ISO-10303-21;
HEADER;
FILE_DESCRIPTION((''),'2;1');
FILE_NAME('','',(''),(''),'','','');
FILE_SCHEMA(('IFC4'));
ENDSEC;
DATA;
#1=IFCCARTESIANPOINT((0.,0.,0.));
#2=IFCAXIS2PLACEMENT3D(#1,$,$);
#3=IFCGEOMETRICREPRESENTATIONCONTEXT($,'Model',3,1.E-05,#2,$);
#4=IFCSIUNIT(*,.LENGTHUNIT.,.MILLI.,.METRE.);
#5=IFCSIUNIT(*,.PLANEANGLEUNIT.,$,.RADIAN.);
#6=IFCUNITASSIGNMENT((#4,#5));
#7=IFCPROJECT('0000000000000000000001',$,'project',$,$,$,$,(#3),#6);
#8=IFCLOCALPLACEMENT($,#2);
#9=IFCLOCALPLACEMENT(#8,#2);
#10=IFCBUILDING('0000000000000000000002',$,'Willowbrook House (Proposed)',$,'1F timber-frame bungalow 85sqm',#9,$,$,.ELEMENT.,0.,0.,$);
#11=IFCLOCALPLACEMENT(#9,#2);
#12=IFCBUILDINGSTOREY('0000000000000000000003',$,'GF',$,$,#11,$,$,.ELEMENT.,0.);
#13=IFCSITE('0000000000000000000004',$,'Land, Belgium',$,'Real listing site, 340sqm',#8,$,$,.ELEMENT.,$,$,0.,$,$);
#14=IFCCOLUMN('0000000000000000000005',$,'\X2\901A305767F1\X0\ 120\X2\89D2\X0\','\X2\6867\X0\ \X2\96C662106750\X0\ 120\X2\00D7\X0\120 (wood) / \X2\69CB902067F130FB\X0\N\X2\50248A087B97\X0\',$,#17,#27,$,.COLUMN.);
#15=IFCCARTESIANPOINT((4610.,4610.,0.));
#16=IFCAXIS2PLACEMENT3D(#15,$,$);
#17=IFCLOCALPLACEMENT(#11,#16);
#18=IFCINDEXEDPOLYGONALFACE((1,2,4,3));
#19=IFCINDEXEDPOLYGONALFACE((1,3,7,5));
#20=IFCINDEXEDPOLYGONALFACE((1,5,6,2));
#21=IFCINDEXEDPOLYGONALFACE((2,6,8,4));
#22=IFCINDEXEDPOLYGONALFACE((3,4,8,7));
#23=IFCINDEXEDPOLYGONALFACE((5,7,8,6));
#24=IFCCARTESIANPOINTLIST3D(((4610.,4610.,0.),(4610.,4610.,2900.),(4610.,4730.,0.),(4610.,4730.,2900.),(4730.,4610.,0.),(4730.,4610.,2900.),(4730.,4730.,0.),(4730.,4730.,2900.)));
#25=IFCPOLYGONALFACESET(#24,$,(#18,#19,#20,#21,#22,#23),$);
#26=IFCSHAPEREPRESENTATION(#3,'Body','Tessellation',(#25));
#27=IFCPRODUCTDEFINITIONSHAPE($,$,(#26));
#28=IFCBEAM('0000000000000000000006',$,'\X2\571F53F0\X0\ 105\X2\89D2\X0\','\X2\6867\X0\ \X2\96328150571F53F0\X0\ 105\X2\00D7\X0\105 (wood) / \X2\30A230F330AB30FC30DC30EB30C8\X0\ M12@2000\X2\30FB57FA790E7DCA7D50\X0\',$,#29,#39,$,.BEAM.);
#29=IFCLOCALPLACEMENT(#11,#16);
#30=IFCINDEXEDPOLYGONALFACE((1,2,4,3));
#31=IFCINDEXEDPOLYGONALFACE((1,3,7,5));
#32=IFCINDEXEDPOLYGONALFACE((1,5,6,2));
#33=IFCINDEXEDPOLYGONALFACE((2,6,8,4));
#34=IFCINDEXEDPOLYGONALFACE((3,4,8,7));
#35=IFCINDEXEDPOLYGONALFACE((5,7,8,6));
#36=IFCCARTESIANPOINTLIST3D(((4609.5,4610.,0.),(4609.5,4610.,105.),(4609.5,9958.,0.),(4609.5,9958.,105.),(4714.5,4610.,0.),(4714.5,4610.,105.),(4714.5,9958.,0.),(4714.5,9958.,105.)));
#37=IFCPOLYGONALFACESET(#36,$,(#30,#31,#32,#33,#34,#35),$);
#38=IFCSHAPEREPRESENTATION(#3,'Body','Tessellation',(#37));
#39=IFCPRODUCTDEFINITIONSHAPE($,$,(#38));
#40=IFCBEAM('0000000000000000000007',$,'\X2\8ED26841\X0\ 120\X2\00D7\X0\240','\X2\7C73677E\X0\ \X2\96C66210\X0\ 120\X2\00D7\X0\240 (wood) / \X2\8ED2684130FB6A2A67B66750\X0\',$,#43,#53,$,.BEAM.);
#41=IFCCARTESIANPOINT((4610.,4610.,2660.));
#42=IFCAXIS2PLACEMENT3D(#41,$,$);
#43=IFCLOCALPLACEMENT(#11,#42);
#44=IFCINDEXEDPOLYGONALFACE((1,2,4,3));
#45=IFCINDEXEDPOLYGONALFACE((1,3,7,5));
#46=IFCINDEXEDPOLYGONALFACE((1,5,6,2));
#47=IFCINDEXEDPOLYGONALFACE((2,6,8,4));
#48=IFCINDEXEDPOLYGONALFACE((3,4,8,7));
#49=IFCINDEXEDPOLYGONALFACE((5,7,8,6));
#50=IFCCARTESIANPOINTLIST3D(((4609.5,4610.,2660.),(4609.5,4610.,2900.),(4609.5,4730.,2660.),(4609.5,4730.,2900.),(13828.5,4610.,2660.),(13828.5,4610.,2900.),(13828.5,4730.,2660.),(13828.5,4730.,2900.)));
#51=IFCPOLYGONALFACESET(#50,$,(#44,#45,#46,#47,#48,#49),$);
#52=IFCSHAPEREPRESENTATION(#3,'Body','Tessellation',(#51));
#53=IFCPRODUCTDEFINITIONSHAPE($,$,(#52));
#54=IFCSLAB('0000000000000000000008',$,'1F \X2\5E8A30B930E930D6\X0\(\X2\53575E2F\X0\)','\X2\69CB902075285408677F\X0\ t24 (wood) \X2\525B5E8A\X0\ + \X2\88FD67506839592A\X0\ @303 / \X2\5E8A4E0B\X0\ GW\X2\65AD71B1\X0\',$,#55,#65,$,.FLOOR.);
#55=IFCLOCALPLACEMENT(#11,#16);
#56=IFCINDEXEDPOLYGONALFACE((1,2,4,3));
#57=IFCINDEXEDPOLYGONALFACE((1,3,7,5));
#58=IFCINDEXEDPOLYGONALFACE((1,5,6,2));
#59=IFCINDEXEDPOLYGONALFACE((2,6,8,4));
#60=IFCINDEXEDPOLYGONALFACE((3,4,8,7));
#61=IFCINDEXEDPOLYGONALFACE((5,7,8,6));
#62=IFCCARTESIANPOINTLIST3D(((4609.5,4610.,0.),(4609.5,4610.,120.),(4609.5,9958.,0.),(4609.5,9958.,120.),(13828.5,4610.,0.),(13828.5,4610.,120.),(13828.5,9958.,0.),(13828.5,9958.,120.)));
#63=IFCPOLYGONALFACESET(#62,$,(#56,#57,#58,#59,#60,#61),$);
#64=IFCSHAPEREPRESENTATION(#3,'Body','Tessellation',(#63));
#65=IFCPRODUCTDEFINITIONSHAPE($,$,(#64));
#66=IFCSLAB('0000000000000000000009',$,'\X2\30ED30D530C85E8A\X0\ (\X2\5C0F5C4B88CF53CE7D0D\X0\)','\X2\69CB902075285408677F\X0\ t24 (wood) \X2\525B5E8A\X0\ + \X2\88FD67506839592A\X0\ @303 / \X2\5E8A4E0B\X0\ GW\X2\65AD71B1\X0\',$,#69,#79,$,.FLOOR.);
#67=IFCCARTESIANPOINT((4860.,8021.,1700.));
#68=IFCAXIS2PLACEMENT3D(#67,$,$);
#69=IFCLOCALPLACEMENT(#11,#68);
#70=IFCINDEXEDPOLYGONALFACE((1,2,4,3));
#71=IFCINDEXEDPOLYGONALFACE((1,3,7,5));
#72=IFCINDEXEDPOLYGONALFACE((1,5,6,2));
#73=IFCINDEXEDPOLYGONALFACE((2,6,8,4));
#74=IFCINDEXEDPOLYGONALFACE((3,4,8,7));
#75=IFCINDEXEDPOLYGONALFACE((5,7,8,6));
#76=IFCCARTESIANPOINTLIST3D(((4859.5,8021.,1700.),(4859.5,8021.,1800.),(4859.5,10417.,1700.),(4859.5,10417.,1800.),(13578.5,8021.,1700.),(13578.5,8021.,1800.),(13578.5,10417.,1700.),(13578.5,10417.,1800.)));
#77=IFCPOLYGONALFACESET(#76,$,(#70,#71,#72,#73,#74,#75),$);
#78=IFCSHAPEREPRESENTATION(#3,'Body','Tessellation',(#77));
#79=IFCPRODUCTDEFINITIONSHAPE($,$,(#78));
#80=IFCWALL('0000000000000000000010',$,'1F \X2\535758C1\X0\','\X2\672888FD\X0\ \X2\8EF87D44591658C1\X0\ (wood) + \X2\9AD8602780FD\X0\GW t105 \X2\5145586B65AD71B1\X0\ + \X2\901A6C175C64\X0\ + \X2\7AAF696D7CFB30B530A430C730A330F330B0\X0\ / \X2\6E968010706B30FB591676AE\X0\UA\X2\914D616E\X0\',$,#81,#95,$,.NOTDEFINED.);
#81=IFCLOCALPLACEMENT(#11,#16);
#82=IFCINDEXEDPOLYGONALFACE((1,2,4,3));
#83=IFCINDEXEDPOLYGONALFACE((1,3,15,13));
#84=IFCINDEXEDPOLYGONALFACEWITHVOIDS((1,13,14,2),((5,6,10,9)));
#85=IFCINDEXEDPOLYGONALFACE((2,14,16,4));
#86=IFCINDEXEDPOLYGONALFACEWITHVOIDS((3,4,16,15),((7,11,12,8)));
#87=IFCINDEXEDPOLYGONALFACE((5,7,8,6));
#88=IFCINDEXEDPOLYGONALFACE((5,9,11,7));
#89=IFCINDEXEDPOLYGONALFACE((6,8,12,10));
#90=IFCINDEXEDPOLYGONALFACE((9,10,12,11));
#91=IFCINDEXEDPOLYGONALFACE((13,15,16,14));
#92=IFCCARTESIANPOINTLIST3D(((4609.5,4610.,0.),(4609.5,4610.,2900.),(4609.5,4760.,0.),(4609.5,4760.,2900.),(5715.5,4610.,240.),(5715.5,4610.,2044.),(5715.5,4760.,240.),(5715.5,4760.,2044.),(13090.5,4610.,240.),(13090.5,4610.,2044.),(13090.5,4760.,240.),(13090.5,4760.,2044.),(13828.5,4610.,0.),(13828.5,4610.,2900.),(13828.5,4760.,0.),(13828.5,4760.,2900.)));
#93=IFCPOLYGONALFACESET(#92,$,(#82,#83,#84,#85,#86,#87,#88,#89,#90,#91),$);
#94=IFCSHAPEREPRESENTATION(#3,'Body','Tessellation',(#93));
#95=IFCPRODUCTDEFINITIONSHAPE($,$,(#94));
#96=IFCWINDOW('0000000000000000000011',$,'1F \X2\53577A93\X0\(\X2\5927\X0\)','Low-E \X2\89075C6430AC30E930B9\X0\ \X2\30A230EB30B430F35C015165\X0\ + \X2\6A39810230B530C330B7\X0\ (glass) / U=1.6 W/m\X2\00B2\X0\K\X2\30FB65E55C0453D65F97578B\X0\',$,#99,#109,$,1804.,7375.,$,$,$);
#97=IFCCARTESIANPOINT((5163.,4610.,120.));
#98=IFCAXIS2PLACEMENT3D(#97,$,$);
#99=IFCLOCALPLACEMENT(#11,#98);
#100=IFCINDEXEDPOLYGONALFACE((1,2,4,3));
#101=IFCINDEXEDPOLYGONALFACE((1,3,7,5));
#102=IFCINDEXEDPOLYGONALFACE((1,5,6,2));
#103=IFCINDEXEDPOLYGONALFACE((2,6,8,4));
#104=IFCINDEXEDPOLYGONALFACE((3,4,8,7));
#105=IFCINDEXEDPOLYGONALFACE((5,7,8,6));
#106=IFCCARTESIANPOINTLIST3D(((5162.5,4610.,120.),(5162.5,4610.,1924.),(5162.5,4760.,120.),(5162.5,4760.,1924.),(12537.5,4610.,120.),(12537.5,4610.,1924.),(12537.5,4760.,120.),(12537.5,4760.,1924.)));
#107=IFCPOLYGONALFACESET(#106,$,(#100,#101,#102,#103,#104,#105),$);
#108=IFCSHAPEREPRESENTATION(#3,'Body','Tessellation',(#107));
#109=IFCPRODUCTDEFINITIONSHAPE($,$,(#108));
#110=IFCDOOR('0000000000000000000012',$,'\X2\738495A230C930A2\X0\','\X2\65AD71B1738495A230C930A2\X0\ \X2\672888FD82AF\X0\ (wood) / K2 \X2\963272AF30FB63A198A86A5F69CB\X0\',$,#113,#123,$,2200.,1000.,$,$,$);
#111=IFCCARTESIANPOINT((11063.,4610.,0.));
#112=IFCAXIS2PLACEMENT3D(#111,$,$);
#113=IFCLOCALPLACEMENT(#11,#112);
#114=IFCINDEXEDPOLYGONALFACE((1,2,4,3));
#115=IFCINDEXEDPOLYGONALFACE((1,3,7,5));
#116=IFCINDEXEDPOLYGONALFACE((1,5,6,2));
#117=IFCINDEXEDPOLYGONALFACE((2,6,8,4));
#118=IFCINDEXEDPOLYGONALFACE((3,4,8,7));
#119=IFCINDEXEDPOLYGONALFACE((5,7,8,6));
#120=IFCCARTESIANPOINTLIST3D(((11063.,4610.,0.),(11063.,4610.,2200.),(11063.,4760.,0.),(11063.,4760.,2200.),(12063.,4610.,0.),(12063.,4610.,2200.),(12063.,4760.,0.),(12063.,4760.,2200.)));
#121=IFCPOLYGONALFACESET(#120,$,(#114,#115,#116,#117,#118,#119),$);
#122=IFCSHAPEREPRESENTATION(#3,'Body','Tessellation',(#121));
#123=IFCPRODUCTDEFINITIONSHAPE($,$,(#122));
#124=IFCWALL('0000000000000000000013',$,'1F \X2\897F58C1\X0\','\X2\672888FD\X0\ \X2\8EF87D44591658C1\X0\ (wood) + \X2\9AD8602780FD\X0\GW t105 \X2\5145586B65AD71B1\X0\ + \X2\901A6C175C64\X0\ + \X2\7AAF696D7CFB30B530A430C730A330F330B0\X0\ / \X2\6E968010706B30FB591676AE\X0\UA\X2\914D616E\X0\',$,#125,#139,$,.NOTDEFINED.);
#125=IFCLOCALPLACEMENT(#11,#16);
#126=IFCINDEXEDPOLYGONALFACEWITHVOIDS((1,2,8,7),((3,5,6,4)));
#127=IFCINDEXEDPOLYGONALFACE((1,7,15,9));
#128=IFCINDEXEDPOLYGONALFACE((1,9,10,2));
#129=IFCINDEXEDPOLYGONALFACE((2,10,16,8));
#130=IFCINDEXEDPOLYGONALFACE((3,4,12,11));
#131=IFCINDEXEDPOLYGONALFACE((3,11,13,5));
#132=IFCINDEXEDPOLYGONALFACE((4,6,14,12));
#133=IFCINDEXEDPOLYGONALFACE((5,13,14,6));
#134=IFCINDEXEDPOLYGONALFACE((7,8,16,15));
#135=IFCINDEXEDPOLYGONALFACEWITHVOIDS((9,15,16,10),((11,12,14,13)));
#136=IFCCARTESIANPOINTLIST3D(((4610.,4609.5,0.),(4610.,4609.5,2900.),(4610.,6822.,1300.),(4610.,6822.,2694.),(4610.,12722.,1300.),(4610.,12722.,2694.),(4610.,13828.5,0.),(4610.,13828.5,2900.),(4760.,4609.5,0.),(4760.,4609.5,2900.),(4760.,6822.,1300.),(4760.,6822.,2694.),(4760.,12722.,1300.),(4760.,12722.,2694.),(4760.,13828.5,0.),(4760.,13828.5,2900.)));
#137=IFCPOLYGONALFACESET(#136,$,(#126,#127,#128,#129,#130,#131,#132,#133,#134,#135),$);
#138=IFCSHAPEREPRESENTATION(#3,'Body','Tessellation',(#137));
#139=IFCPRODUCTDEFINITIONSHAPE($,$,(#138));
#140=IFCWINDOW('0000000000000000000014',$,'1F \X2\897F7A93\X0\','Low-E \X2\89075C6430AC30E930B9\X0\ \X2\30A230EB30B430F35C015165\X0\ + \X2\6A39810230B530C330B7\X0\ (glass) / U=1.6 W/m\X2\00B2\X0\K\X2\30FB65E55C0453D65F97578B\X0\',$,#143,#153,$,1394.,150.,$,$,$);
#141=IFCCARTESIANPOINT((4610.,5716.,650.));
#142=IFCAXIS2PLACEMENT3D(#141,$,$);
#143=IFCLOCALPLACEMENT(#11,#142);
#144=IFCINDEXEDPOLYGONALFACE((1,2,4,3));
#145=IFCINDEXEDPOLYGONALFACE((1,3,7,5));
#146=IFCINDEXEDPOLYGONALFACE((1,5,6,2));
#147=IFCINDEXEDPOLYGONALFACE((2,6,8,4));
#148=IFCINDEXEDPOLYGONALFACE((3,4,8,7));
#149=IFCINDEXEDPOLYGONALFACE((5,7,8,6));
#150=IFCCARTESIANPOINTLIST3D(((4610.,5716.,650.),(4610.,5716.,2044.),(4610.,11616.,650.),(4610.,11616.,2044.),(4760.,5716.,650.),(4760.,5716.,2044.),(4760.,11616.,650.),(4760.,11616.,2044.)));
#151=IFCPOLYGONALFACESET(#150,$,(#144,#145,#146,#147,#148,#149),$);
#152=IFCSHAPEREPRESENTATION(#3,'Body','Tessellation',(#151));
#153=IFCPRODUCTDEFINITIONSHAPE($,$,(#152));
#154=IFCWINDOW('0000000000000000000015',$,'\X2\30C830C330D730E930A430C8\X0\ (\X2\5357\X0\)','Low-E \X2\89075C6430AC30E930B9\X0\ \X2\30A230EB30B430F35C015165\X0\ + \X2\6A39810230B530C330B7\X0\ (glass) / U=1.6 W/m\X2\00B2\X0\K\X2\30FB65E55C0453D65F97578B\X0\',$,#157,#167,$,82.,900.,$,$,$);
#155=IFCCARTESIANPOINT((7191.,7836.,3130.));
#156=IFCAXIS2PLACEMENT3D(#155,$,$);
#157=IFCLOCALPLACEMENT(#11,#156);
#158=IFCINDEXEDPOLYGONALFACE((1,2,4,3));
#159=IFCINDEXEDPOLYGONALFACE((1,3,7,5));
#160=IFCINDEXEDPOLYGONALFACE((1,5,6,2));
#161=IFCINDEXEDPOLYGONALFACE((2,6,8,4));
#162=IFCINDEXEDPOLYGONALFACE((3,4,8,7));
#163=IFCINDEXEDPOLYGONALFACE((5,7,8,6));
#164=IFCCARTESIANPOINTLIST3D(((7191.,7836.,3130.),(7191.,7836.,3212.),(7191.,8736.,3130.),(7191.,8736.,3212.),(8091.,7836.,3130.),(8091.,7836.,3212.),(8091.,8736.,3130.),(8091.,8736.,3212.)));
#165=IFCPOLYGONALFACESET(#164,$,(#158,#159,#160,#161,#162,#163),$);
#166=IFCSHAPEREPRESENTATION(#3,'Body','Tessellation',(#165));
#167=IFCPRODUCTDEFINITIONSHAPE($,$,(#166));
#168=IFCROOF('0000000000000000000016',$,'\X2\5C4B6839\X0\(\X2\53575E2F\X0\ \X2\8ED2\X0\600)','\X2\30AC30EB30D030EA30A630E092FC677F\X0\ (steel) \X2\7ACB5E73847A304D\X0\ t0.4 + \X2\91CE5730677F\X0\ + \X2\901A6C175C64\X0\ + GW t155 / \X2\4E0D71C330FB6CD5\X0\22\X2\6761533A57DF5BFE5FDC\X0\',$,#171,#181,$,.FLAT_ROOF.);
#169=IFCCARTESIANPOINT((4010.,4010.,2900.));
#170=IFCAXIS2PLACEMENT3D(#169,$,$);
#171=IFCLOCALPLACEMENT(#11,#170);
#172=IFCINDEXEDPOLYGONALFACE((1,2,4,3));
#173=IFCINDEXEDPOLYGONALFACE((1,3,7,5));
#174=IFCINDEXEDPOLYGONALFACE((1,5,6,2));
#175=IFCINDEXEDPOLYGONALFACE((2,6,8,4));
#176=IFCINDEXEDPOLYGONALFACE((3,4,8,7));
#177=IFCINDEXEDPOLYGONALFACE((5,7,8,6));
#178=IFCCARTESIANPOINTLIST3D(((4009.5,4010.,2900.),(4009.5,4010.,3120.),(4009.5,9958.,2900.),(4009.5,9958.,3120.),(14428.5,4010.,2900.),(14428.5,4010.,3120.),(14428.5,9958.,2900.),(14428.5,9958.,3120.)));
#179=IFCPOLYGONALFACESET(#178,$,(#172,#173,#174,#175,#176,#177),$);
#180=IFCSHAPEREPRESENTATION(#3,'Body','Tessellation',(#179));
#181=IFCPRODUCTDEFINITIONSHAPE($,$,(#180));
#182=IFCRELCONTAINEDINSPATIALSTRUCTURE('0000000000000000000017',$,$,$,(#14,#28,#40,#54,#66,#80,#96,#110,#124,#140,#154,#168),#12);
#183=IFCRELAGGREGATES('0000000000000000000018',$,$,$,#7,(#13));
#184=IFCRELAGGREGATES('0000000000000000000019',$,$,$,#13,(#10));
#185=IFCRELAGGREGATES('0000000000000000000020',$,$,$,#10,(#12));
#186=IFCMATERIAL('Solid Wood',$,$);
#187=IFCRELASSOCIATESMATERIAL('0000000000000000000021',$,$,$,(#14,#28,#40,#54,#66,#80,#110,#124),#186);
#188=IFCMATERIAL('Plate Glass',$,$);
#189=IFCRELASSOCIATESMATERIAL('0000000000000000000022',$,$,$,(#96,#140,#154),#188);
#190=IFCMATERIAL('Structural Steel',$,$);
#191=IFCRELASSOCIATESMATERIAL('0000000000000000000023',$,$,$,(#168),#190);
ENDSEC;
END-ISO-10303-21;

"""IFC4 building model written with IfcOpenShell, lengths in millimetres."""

from ifc_helpers import new_model, si_unit, frame, frame_2d, origin, place, context, project, spatial, rectangle, extrude, material, element, fill, save


model = new_model("IFC4")

# Units and contexts
model_context = context("Model", 3, precision=1e-05, world=origin())
ifc_project = project(units=[si_unit("LENGTHUNIT", "METRE", prefix="MILLI"), si_unit("PLANEANGLEUNIT", "RADIAN")], contexts=[model_context])

# Site, building, storey
site_placement = place(None, origin())
site = spatial("IfcSite", under=ifc_project, at=site_placement, Name="Land, Belgium", ObjectType="Real listing site, 340sqm", CompositionType="ELEMENT", RefElevation=0.0)
building_placement = place(site_placement, origin())
building = spatial("IfcBuilding", under=site, at=building_placement, Name="Willowbrook House (Proposed)", ObjectType="1F timber-frame bungalow 85sqm", CompositionType="ELEMENT", ElevationOfRefHeight=0.0, ElevationOfTerrain=0.0)
storey_placement = place(building_placement, origin())
storey = spatial("IfcBuildingStorey", under=building, at=storey_placement, Name="GF", CompositionType="ELEMENT", Elevation=0.0)

# Column
ifc_material_1 = material(Name="Solid Wood")
column_1_placement = place(storey_placement, frame((4610.0, 4610.0, 0.0)))
element("IfcColumn", 1, at=column_1_placement, inside=storey, material=ifc_material_1, Name="通し柱 120角", Description="桧 集成材 120×120 (wood) / 構造柱・N値計算", PredefinedType="COLUMN", context=model_context, shape_type="SweptSolid", body=[
    extrude(rectangle(XDim=120.0, YDim=120.0, at=frame_2d((60.0, 60.0))), frame((4610.0, 4610.0, 0.0)), (0.0, 0.0, 1.0), 2900.0),
])

# Beams
beam_1_placement = place(storey_placement, frame((4610.0, 4610.0, 0.0)))
element("IfcBeam", 2, at=beam_1_placement, inside=storey, material=ifc_material_1, Name="土台 105角", Description="桧 防腐土台 105×105 (wood) / アンカーボルト M12@2000・基礎緊結", PredefinedType="BEAM", context=model_context, shape_type="SweptSolid", body=[
    extrude(rectangle(XDim=105.0, YDim=5348.0, at=frame_2d((52.0, 2674.0))), frame((4610.0, 4610.0, 0.0)), (0.0, 0.0, 1.0), 105.0),
])
beam_2_placement = place(storey_placement, frame((4610.0, 4610.0, 2660.0)))
element("IfcBeam", 3, at=beam_2_placement, inside=storey, material=ifc_material_1, Name="軒桁 120×240", Description="米松 集成 120×240 (wood) / 軒桁・横架材", PredefinedType="BEAM", context=model_context, shape_type="SweptSolid", body=[
    extrude(rectangle(XDim=9219.0, YDim=120.0, at=frame_2d((4609.0, 60.0))), frame((4610.0, 4610.0, 2660.0)), (0.0, 0.0, 1.0), 240.0),
])

# Slabs
slab_1_placement = place(storey_placement, frame((4610.0, 4610.0, 0.0)))
element("IfcSlab", 4, at=slab_1_placement, inside=storey, material=ifc_material_1, Name="1F 床スラブ(南帯)", Description="構造用合板 t24 (wood) 剛床 + 製材根太 @303 / 床下 GW断熱", PredefinedType="FLOOR", context=model_context, shape_type="SweptSolid", body=[
    extrude(rectangle(XDim=9219.0, YDim=5348.0, at=frame_2d((4609.0, 2674.0))), frame((4610.0, 4610.0, 0.0)), (0.0, 0.0, 1.0), 120.0),
])
slab_2_placement = place(storey_placement, frame((4860.0, 8021.0, 1700.0)))
element("IfcSlab", 5, at=slab_2_placement, inside=storey, material=ifc_material_1, Name="ロフト床 (小屋裏収納)", Description="構造用合板 t24 (wood) 剛床 + 製材根太 @303 / 床下 GW断熱", PredefinedType="FLOOR", context=model_context, shape_type="SweptSolid", body=[
    extrude(rectangle(XDim=8719.0, YDim=2396.0, at=frame_2d((4359.0, 1198.0))), frame((4860.0, 8021.0, 1700.0)), (0.0, 0.0, 1.0), 100.0),
])

# Wall, openings, window, door
wall_1_placement = place(storey_placement, frame((4610.0, 4610.0, 0.0)))
wall_1 = element("IfcWall", 6, at=wall_1_placement, inside=storey, material=ifc_material_1, Name="1F 南壁", Description="木製 軸組外壁 (wood) + 高性能GW t105 充填断熱 + 通気層 + 窯業系サイディング / 準耐火・外皮UA配慮", PredefinedType="NOTDEFINED", context=model_context, shape_type="SweptSolid", body=[
    extrude(rectangle(XDim=9219.0, YDim=150.0, at=frame_2d((4609.0, 75.0))), frame((4610.0, 4610.0, 0.0)), (0.0, 0.0, 1.0), 2900.0),
])
opening_1_placement = place(storey_placement, frame((5163.0, 4610.0, 120.0)))
opening_1 = element("IfcOpeningElement", 7, at=opening_1_placement, cuts=wall_1, PredefinedType="NOTDEFINED", context=model_context, shape_type="SweptSolid", body=[
    extrude(rectangle(XDim=7375.0, YDim=150.0, at=frame_2d((3687.0, 75.0))), frame((5163.0, 4610.0, 120.0)), (0.0, 0.0, 1.0), 1804.0),
])
opening_2_placement = place(storey_placement, frame((11063.0, 4610.0, 0.0)))
opening_2 = element("IfcOpeningElement", 8, at=opening_2_placement, cuts=wall_1, PredefinedType="NOTDEFINED", context=model_context, shape_type="SweptSolid", body=[
    extrude(rectangle(XDim=1000.0, YDim=150.0, at=frame_2d((500.0, 75.0))), frame((11063.0, 4610.0, 0.0)), (0.0, 0.0, 1.0), 2200.0),
])
ifc_material_2 = material(Name="Plate Glass")
window_1_placement = place(storey_placement, frame((5163.0, 4610.0, 120.0)))
window_1 = element("IfcWindow", 9, at=window_1_placement, inside=storey, material=ifc_material_2, Name="1F 南窓(大)", Description="Low-E 複層ガラス アルゴン封入 + 樹脂サッシ (glass) / U=1.6 W/m²K・日射取得型", OverallHeight=1804.0, OverallWidth=7375.0, context=model_context, shape_type="SweptSolid", body=[
    extrude(rectangle(XDim=7375.0, YDim=150.0, at=frame_2d((3687.0, 75.0))), frame((5163.0, 4610.0, 120.0)), (0.0, 0.0, 1.0), 1804.0),
])
fill(opening_1, window_1)
door_1_placement = place(storey_placement, frame((11063.0, 4610.0, 0.0)))
door_1 = element("IfcDoor", 10, at=door_1_placement, inside=storey, material=ifc_material_1, Name="玄関ドア", Description="断熱玄関ドア 木製芯 (wood) / K2 防犯・採風機構", OverallHeight=2200.0, OverallWidth=1000.0, context=model_context, shape_type="SweptSolid", body=[
    extrude(rectangle(XDim=1000.0, YDim=150.0, at=frame_2d((500.0, 75.0))), frame((11063.0, 4610.0, 0.0)), (0.0, 0.0, 1.0), 2200.0),
])
fill(opening_2, door_1)

# Wall, opening, window
wall_2_placement = place(storey_placement, frame((4610.0, 4610.0, 0.0)))
wall_2 = element("IfcWall", 11, at=wall_2_placement, inside=storey, material=ifc_material_1, Name="1F 西壁", Description="木製 軸組外壁 (wood) + 高性能GW t105 充填断熱 + 通気層 + 窯業系サイディング / 準耐火・外皮UA配慮", PredefinedType="NOTDEFINED", context=model_context, shape_type="SweptSolid", body=[
    extrude(rectangle(XDim=150.0, YDim=9219.0, at=frame_2d((75.0, 4609.0))), frame((4610.0, 4610.0, 0.0)), (0.0, 0.0, 1.0), 2900.0),
])
opening_3_placement = place(storey_placement, frame((4610.0, 5716.0, 650.0)))
opening_3 = element("IfcOpeningElement", 12, at=opening_3_placement, cuts=wall_2, PredefinedType="NOTDEFINED", context=model_context, shape_type="SweptSolid", body=[
    extrude(rectangle(XDim=150.0, YDim=5900.0, at=frame_2d((75.0, 2950.0))), frame((4610.0, 5716.0, 650.0)), (0.0, 0.0, 1.0), 1394.0),
])
window_2_placement = place(storey_placement, frame((4610.0, 5716.0, 650.0)))
window_2 = element("IfcWindow", 13, at=window_2_placement, inside=storey, material=ifc_material_2, Name="1F 西窓", Description="Low-E 複層ガラス アルゴン封入 + 樹脂サッシ (glass) / U=1.6 W/m²K・日射取得型", OverallHeight=1394.0, OverallWidth=150.0, context=model_context, shape_type="SweptSolid", body=[
    extrude(rectangle(XDim=150.0, YDim=5900.0, at=frame_2d((75.0, 2950.0))), frame((4610.0, 5716.0, 650.0)), (0.0, 0.0, 1.0), 1394.0),
])
fill(opening_3, window_2)

# Window
window_3_placement = place(storey_placement, frame((7191.0, 7836.0, 3130.0)))
element("IfcWindow", 14, at=window_3_placement, inside=storey, material=ifc_material_2, Name="トップライト (南)", Description="Low-E 複層ガラス アルゴン封入 + 樹脂サッシ (glass) / U=1.6 W/m²K・日射取得型", OverallHeight=82.0, OverallWidth=900.0, context=model_context, shape_type="SweptSolid", body=[
    extrude(rectangle(XDim=900.0, YDim=900.0, at=frame_2d((450.0, 450.0))), frame((7191.0, 7836.0, 3130.0)), (0.0, 0.0, 1.0), 82.0),
])

# Roof
ifc_material_3 = material(Name="Structural Steel")
roof_placement = place(storey_placement, frame((4010.0, 4010.0, 2900.0)))
element("IfcRoof", 15, at=roof_placement, inside=storey, material=ifc_material_3, Name="屋根(南帯 軒600)", Description="ガルバリウム鋼板 (steel) 立平葺き t0.4 + 野地板 + 通気層 + GW t155 / 不燃・法22条区域対応", PredefinedType="FLAT_ROOF", context=model_context, shape_type="SweptSolid", body=[
    extrude(rectangle(XDim=10419.0, YDim=5948.0, at=frame_2d((5209.0, 2974.0))), frame((4010.0, 4010.0, 2900.0)), (0.0, 0.0, 1.0), 220.0),
])

save(model, "model.ifc")
